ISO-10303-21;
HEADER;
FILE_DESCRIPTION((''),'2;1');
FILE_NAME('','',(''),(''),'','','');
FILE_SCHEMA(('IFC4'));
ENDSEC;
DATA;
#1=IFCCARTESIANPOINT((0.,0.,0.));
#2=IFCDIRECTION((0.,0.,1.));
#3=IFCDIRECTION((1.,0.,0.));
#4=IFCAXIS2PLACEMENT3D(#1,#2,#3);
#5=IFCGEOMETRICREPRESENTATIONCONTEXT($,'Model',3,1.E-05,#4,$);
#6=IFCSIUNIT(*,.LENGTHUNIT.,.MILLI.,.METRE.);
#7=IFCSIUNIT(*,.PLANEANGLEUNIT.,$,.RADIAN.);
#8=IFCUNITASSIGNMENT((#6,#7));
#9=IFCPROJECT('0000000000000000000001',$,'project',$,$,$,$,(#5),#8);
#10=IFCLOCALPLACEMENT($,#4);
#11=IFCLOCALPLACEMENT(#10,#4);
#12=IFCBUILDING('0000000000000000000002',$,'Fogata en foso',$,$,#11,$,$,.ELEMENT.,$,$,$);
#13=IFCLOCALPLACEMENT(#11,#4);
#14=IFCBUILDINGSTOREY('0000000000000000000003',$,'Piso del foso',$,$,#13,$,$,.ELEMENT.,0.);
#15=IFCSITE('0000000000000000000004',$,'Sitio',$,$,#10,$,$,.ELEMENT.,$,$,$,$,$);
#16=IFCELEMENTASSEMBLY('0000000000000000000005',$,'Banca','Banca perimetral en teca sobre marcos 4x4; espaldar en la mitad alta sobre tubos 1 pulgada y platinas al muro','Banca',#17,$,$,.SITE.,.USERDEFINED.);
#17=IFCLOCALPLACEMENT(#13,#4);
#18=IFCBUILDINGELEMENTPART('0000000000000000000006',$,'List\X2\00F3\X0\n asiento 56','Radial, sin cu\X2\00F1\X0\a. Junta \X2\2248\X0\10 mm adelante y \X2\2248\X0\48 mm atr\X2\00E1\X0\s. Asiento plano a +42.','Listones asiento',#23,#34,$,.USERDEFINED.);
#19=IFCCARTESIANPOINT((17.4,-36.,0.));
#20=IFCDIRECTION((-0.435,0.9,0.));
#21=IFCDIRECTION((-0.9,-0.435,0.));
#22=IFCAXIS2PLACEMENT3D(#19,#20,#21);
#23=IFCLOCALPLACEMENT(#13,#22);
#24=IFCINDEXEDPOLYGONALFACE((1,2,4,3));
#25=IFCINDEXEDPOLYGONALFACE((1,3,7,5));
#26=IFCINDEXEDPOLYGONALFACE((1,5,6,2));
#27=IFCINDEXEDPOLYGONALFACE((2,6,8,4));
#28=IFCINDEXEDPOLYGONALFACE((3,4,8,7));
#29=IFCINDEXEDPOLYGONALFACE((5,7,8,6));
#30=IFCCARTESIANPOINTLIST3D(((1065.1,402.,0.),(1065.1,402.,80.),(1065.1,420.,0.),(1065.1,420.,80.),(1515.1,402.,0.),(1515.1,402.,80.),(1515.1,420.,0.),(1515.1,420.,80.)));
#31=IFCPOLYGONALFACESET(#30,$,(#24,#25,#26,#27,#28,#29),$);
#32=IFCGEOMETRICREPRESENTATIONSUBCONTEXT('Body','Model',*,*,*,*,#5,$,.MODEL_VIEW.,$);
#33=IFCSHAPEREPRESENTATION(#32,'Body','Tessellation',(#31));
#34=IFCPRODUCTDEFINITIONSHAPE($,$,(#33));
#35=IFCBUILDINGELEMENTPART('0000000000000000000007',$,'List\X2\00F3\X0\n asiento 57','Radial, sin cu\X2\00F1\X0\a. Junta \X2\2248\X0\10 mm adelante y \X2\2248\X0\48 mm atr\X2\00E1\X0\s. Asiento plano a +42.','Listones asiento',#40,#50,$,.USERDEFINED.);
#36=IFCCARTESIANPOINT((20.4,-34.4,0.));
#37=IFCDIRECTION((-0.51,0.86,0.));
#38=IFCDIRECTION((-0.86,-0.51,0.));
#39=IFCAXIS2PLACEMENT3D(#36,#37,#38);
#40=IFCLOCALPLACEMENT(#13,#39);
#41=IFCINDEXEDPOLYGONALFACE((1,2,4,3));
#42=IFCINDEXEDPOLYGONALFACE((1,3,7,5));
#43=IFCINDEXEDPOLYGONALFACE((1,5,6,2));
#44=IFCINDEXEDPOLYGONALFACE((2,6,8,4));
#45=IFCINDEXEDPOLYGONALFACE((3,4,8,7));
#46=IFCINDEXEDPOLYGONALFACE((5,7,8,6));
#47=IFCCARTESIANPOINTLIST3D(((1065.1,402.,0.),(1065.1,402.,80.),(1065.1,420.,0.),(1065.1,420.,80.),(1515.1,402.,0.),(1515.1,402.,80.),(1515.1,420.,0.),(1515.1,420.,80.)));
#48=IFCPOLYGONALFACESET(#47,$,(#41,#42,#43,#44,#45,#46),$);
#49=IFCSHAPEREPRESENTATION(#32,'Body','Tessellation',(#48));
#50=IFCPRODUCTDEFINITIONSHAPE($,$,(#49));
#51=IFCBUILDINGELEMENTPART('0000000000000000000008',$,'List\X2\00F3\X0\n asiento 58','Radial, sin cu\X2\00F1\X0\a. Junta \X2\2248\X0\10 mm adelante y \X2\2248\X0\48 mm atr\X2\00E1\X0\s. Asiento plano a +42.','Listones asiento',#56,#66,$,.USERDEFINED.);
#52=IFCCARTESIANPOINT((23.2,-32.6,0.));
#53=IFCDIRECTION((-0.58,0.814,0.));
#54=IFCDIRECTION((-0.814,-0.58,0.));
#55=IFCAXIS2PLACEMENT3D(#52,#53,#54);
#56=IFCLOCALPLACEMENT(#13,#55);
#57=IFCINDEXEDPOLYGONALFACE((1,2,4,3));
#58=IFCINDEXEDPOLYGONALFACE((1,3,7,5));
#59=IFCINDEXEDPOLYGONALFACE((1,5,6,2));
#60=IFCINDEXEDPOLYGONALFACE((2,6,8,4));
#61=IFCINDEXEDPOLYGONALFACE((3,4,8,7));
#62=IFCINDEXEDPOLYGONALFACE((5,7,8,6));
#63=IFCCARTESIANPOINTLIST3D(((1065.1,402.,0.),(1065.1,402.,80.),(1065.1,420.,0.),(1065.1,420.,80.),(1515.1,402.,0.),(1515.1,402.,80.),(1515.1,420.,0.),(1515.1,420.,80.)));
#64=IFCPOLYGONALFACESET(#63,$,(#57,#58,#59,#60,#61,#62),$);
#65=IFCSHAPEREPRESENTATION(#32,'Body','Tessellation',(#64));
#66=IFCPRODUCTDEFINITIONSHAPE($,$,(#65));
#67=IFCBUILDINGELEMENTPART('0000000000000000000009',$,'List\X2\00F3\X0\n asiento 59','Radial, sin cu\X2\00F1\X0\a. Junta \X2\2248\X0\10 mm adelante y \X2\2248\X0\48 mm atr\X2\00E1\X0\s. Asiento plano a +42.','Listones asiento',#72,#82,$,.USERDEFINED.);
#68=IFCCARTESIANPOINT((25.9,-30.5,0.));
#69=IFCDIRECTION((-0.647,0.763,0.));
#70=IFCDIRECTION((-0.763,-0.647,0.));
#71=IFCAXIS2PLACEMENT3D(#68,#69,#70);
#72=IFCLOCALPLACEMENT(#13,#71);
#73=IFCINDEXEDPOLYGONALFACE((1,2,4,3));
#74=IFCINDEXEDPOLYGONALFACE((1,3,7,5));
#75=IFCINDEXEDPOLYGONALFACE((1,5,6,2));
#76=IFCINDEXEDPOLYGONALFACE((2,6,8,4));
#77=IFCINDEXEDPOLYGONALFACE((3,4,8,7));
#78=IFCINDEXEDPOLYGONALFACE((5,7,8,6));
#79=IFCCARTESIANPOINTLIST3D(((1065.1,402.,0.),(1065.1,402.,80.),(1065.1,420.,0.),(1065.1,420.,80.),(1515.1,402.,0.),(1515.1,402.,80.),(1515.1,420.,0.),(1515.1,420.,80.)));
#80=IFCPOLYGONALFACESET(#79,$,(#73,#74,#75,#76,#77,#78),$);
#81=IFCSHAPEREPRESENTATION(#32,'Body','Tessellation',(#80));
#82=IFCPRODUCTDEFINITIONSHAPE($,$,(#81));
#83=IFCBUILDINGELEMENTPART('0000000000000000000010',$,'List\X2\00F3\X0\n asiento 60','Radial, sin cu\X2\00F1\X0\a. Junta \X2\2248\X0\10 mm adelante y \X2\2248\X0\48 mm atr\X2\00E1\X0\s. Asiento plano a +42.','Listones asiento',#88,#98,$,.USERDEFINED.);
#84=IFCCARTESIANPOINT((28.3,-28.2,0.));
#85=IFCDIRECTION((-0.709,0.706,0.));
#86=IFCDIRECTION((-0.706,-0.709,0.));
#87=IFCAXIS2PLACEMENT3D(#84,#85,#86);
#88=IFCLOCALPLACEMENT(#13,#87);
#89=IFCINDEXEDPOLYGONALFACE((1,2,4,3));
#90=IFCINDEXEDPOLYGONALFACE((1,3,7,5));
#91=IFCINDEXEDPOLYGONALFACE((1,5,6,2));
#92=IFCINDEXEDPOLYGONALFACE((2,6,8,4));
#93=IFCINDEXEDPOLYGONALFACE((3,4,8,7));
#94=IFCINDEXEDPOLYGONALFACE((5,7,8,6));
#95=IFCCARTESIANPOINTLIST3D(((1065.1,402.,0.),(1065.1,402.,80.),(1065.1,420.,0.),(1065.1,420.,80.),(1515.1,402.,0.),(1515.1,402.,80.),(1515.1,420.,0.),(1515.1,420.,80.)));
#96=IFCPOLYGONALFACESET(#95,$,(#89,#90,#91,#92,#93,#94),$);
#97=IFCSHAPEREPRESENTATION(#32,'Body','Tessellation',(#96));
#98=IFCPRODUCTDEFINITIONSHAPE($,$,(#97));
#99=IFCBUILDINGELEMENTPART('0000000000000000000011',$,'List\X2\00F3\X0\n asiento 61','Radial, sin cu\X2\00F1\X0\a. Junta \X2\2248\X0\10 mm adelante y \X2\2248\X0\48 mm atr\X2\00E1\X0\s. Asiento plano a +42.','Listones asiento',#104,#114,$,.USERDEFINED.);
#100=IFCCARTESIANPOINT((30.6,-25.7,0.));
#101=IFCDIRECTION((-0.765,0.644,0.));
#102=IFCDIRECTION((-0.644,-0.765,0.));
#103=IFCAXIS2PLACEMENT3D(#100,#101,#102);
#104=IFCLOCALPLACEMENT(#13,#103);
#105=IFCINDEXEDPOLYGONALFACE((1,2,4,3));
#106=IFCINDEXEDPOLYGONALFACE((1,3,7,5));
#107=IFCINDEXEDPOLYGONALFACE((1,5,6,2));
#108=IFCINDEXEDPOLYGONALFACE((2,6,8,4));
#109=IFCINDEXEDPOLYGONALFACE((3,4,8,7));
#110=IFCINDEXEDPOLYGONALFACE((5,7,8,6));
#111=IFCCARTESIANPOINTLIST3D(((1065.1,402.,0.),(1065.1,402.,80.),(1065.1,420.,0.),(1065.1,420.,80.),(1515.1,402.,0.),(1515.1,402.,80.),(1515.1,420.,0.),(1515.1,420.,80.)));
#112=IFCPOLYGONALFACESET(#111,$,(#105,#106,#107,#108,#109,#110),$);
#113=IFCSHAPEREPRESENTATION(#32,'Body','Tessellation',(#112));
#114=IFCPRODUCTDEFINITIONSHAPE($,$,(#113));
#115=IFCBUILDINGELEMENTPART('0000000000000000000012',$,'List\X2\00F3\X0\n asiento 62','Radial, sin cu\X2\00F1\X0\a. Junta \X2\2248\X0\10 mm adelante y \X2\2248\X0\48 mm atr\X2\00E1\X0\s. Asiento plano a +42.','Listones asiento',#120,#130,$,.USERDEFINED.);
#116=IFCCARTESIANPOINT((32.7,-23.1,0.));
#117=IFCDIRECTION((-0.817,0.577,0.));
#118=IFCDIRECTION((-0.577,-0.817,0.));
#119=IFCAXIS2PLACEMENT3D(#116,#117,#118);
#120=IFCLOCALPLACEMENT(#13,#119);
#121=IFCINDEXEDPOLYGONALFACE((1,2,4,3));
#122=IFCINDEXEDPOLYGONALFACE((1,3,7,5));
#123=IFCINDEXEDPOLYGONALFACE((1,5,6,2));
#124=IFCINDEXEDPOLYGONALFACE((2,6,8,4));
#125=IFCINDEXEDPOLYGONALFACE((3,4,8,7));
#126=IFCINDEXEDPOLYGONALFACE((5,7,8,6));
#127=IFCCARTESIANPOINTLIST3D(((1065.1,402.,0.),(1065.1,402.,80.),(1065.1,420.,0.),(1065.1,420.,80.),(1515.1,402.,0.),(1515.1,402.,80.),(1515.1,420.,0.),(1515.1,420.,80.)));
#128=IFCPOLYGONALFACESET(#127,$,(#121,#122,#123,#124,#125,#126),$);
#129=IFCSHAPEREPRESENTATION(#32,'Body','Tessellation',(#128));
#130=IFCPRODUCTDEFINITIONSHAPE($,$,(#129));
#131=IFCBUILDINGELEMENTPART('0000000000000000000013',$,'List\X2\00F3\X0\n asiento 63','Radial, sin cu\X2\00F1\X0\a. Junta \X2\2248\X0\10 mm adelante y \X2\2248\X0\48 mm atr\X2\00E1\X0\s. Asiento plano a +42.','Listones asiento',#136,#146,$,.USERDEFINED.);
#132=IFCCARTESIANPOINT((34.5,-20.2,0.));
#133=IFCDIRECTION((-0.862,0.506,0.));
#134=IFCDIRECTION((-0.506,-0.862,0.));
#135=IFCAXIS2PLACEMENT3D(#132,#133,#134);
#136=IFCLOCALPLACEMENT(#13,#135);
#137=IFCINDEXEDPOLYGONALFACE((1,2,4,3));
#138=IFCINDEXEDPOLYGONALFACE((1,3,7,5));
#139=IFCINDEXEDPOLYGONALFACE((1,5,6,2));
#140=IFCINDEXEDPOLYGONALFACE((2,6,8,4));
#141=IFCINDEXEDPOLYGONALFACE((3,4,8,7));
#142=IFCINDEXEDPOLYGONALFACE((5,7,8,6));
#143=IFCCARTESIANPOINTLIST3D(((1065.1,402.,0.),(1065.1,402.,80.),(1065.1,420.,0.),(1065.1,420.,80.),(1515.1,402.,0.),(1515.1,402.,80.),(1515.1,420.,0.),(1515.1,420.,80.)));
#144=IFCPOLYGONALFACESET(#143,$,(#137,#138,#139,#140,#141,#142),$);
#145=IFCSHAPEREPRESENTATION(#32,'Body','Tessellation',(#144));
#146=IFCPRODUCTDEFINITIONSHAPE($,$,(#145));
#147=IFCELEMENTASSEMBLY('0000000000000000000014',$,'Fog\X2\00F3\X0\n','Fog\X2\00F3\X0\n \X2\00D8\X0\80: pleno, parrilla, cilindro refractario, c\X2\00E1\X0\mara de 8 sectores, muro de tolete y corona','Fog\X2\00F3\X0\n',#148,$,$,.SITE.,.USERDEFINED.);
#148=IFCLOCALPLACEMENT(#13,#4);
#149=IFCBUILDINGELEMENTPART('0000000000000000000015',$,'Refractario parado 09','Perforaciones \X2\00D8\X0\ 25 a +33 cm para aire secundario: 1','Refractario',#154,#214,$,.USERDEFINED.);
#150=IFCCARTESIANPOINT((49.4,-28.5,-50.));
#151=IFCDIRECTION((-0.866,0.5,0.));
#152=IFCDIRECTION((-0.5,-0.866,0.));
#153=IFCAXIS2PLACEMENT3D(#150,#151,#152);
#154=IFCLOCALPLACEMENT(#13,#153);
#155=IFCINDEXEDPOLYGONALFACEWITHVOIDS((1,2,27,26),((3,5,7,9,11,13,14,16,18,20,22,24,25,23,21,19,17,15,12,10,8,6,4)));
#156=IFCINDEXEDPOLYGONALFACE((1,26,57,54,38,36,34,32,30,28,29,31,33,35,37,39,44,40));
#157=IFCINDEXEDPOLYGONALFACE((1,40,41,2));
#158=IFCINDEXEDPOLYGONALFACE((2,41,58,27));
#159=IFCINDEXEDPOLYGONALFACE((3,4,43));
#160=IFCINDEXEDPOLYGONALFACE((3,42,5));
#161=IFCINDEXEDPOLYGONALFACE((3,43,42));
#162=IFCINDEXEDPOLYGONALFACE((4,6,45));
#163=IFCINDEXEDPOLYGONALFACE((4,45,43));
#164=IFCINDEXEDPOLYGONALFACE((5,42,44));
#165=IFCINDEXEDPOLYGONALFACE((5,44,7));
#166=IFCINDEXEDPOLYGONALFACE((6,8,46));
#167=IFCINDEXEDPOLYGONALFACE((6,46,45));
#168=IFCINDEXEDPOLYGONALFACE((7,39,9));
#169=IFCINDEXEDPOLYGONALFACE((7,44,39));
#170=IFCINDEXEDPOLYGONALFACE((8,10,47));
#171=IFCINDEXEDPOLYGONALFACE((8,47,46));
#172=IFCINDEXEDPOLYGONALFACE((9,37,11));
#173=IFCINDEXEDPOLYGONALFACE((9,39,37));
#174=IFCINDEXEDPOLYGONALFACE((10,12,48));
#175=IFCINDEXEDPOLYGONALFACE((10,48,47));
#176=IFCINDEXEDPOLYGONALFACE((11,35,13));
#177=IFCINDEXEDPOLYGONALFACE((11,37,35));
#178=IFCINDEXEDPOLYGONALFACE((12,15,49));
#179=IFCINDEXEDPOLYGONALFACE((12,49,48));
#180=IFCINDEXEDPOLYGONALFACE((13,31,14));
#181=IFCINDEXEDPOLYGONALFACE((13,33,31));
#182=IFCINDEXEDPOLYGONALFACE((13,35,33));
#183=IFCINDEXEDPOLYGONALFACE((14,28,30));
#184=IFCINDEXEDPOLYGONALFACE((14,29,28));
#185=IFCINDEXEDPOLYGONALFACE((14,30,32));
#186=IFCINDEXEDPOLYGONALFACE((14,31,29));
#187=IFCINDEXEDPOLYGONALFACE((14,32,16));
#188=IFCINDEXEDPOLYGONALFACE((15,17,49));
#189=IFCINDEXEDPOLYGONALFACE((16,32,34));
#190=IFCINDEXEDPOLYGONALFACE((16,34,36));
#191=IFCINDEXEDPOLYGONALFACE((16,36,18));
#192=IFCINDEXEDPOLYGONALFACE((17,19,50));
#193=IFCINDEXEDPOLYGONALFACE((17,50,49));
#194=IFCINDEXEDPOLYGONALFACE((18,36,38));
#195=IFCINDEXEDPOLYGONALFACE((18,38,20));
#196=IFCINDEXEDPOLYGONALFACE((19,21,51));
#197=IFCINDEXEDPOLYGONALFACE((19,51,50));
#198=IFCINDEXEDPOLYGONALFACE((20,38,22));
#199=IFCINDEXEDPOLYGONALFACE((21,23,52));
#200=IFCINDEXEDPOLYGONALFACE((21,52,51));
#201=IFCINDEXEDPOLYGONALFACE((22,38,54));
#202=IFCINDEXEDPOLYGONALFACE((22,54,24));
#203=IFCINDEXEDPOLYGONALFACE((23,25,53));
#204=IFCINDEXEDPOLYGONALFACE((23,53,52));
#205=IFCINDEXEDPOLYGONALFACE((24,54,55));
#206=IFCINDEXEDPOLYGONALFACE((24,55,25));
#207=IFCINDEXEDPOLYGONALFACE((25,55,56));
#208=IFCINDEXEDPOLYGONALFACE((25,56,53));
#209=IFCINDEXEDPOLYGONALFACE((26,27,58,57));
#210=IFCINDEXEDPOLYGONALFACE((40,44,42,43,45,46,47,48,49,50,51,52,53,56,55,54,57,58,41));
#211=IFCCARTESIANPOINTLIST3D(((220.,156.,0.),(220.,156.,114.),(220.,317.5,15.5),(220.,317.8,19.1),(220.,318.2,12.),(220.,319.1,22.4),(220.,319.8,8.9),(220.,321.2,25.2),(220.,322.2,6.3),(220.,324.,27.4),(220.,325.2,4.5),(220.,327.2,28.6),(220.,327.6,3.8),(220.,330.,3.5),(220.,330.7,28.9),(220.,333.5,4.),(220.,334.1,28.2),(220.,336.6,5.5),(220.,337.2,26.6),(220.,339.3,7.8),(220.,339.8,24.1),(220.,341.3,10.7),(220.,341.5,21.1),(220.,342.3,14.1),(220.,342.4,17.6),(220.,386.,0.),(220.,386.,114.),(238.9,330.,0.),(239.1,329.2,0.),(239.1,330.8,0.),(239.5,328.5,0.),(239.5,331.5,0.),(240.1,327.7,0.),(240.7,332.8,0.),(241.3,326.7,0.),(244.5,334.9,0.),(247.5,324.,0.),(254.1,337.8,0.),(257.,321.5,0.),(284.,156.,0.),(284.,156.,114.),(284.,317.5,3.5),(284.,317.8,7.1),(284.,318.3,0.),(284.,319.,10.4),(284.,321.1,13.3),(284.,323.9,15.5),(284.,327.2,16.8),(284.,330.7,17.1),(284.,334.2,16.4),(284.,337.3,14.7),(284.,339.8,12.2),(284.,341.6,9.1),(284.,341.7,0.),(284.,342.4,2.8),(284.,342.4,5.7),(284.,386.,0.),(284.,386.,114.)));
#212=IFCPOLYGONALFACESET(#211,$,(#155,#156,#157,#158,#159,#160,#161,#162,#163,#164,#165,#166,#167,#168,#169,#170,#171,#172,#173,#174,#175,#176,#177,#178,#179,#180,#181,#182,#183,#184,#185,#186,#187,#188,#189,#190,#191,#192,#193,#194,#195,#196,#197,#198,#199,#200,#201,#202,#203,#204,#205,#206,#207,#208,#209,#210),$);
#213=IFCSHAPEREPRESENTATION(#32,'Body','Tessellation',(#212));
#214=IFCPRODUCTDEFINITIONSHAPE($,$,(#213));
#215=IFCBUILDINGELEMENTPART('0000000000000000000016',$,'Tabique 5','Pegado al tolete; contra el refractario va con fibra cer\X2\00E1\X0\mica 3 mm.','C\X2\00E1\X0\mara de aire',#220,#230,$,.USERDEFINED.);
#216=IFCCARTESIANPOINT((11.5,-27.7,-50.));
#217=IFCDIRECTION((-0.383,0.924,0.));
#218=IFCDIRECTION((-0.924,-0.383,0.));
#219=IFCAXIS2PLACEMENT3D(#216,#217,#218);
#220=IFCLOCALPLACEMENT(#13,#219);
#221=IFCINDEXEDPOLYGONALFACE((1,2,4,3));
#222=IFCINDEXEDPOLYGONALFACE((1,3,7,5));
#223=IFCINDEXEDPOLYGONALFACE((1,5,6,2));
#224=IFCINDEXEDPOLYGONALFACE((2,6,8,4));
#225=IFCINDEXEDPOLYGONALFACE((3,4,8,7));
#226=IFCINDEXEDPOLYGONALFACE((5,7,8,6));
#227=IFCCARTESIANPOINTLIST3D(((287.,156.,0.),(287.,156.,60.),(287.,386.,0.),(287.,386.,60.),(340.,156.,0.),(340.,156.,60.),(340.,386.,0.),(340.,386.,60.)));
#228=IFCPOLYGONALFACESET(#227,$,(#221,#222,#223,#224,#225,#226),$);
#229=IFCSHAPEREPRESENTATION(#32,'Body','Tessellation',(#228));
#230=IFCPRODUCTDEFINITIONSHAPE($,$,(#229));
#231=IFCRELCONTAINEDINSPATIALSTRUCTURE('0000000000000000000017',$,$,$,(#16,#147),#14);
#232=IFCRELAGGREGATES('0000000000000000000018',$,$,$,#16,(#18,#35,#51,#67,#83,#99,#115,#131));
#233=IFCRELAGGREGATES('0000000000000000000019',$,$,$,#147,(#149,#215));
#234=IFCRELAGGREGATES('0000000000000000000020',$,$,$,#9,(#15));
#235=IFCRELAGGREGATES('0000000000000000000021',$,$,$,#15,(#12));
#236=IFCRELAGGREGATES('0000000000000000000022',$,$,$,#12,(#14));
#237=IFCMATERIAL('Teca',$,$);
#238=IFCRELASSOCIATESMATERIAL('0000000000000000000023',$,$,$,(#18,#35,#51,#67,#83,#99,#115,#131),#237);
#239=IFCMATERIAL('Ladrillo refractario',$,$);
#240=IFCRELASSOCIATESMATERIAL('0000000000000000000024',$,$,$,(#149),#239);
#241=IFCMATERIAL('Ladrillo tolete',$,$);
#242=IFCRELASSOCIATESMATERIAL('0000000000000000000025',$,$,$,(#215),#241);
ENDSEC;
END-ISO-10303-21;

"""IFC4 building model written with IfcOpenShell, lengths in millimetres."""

from ifc_helpers import new_model, si_unit, frame, origin_with_axes, origin_2d, place, context, subcontext, project, spatial, polyline, circle, outline, extrude, material, element, aggregate, save


model = new_model("IFC4")

# Units and contexts
model_context = context("Model", 3, precision=1e-05, world=origin_with_axes())
body_context = subcontext(model_context, "Body", "Model", "MODEL_VIEW")
ifc_project = project(units=[si_unit("LENGTHUNIT", "METRE", prefix="MILLI"), si_unit("PLANEANGLEUNIT", "RADIAN")], contexts=[model_context])

# Site, building, storey
site_placement = place(None, origin_with_axes())
site = spatial("IfcSite", under=ifc_project, at=site_placement, Name="Sitio", CompositionType="ELEMENT")
building_placement = place(site_placement, origin_with_axes())
building = spatial("IfcBuilding", under=site, at=building_placement, Name="Fogata en foso", CompositionType="ELEMENT")
storey_placement = place(building_placement, origin_with_axes())
storey = spatial("IfcBuildingStorey", under=building, at=storey_placement, Name="Piso del foso", CompositionType="ELEMENT", Elevation=0.0)

# Element assembly, building element parts
assembly_1_placement = place(storey_placement, origin_with_axes())
assembly_1 = element("IfcElementAssembly", 1, at=assembly_1_placement, inside=storey, Name="Banca", Description="Banca perimetral en teca sobre marcos 4x4; espaldar en la mitad alta sobre tubos 1 pulgada y platinas al muro", ObjectType="Banca", AssemblyPlace="SITE", PredefinedType="USERDEFINED")
ifc_material_1 = material(Name="Teca")
building_element_part_1_placement = place(storey_placement, frame((17.4, -36.0, 0.0), z_axis=(-0.435, 0.9, 0.0), x_axis=(-0.9, -0.435, 0.0)))
building_element_part_1 = element("IfcBuildingElementPart", 2, at=building_element_part_1_placement, material=ifc_material_1, Name="Listón asiento 56", Description="Radial, sin cuña. Junta ≈10 mm adelante y ≈48 mm atrás. Asiento plano a +42.", ObjectType="Listones asiento", PredefinedType="USERDEFINED", context=body_context, shape_type="SweptSolid", body=[
    extrude(outline(polyline([(1065.1, 402.0), (1515.1, 402.0), (1515.1, 420.0), (1065.1, 420.0), (1065.1, 402.0)])), origin_with_axes(), (0.0, 0.0, 1.0), 80.0),
])
building_element_part_2_placement = place(storey_placement, frame((20.4, -34.4, 0.0), z_axis=(-0.51, 0.86, 0.0), x_axis=(-0.86, -0.51, 0.0)))
building_element_part_2 = element("IfcBuildingElementPart", 3, at=building_element_part_2_placement, material=ifc_material_1, Name="Listón asiento 57", Description="Radial, sin cuña. Junta ≈10 mm adelante y ≈48 mm atrás. Asiento plano a +42.", ObjectType="Listones asiento", PredefinedType="USERDEFINED", context=body_context, shape_type="SweptSolid", body=[
    extrude(outline(polyline([(1065.1, 402.0), (1515.1, 402.0), (1515.1, 420.0), (1065.1, 420.0), (1065.1, 402.0)])), origin_with_axes(), (0.0, 0.0, 1.0), 80.0),
])
building_element_part_3_placement = place(storey_placement, frame((23.2, -32.6, 0.0), z_axis=(-0.58, 0.814, 0.0), x_axis=(-0.814, -0.58, 0.0)))
building_element_part_3 = element("IfcBuildingElementPart", 4, at=building_element_part_3_placement, material=ifc_material_1, Name="Listón asiento 58", Description="Radial, sin cuña. Junta ≈10 mm adelante y ≈48 mm atrás. Asiento plano a +42.", ObjectType="Listones asiento", PredefinedType="USERDEFINED", context=body_context, shape_type="SweptSolid", body=[
    extrude(outline(polyline([(1065.1, 402.0), (1515.1, 402.0), (1515.1, 420.0), (1065.1, 420.0), (1065.1, 402.0)])), origin_with_axes(), (0.0, 0.0, 1.0), 80.0),
])
building_element_part_4_placement = place(storey_placement, frame((25.9, -30.5, 0.0), z_axis=(-0.647, 0.763, 0.0), x_axis=(-0.763, -0.647, 0.0)))
building_element_part_4 = element("IfcBuildingElementPart", 5, at=building_element_part_4_placement, material=ifc_material_1, Name="Listón asiento 59", Description="Radial, sin cuña. Junta ≈10 mm adelante y ≈48 mm atrás. Asiento plano a +42.", ObjectType="Listones asiento", PredefinedType="USERDEFINED", context=body_context, shape_type="SweptSolid", body=[
    extrude(outline(polyline([(1065.1, 402.0), (1515.1, 402.0), (1515.1, 420.0), (1065.1, 420.0), (1065.1, 402.0)])), origin_with_axes(), (0.0, 0.0, 1.0), 80.0),
])
building_element_part_5_placement = place(storey_placement, frame((28.3, -28.2, 0.0), z_axis=(-0.709, 0.706, 0.0), x_axis=(-0.706, -0.709, 0.0)))
building_element_part_5 = element("IfcBuildingElementPart", 6, at=building_element_part_5_placement, material=ifc_material_1, Name="Listón asiento 60", Description="Radial, sin cuña. Junta ≈10 mm adelante y ≈48 mm atrás. Asiento plano a +42.", ObjectType="Listones asiento", PredefinedType="USERDEFINED", context=body_context, shape_type="SweptSolid", body=[
    extrude(outline(polyline([(1065.1, 402.0), (1515.1, 402.0), (1515.1, 420.0), (1065.1, 420.0), (1065.1, 402.0)])), origin_with_axes(), (0.0, 0.0, 1.0), 80.0),
])
building_element_part_6_placement = place(storey_placement, frame((30.6, -25.7, 0.0), z_axis=(-0.765, 0.644, 0.0), x_axis=(-0.644, -0.765, 0.0)))
building_element_part_6 = element("IfcBuildingElementPart", 7, at=building_element_part_6_placement, material=ifc_material_1, Name="Listón asiento 61", Description="Radial, sin cuña. Junta ≈10 mm adelante y ≈48 mm atrás. Asiento plano a +42.", ObjectType="Listones asiento", PredefinedType="USERDEFINED", context=body_context, shape_type="SweptSolid", body=[
    extrude(outline(polyline([(1065.1, 402.0), (1515.1, 402.0), (1515.1, 420.0), (1065.1, 420.0), (1065.1, 402.0)])), origin_with_axes(), (0.0, 0.0, 1.0), 80.0),
])
building_element_part_7_placement = place(storey_placement, frame((32.7, -23.1, 0.0), z_axis=(-0.817, 0.577, 0.0), x_axis=(-0.577, -0.817, 0.0)))
building_element_part_7 = element("IfcBuildingElementPart", 8, at=building_element_part_7_placement, material=ifc_material_1, Name="Listón asiento 62", Description="Radial, sin cuña. Junta ≈10 mm adelante y ≈48 mm atrás. Asiento plano a +42.", ObjectType="Listones asiento", PredefinedType="USERDEFINED", context=body_context, shape_type="SweptSolid", body=[
    extrude(outline(polyline([(1065.1, 402.0), (1515.1, 402.0), (1515.1, 420.0), (1065.1, 420.0), (1065.1, 402.0)])), origin_with_axes(), (0.0, 0.0, 1.0), 80.0),
])
building_element_part_8_placement = place(storey_placement, frame((34.5, -20.2, 0.0), z_axis=(-0.862, 0.506, 0.0), x_axis=(-0.506, -0.862, 0.0)))
building_element_part_8 = element("IfcBuildingElementPart", 9, at=building_element_part_8_placement, material=ifc_material_1, Name="Listón asiento 63", Description="Radial, sin cuña. Junta ≈10 mm adelante y ≈48 mm atrás. Asiento plano a +42.", ObjectType="Listones asiento", PredefinedType="USERDEFINED", context=body_context, shape_type="SweptSolid", body=[
    extrude(outline(polyline([(1065.1, 402.0), (1515.1, 402.0), (1515.1, 420.0), (1065.1, 420.0), (1065.1, 402.0)])), origin_with_axes(), (0.0, 0.0, 1.0), 80.0),
])
aggregate(assembly_1, [building_element_part_1, building_element_part_2, building_element_part_3, building_element_part_4, building_element_part_5, building_element_part_6, building_element_part_7, building_element_part_8])

# Element assembly, building element parts, opening
assembly_2_placement = place(storey_placement, origin_with_axes())
assembly_2 = element("IfcElementAssembly", 10, at=assembly_2_placement, inside=storey, Name="Fogón", Description="Fogón Ø80: pleno, parrilla, cilindro refractario, cámara de 8 sectores, muro de tolete y corona", ObjectType="Fogón", AssemblyPlace="SITE", PredefinedType="USERDEFINED")
ifc_material_2 = material(Name="Ladrillo refractario")
building_element_part_9_placement = place(storey_placement, frame((49.4, -28.5, -50.0), z_axis=(-0.866, 0.5, 0.0), x_axis=(-0.5, -0.866, 0.0)))
building_element_part_9 = element("IfcBuildingElementPart", 11, at=building_element_part_9_placement, material=ifc_material_2, Name="Refractario parado 09", Description="Perforaciones Ø 25 a +33 cm para aire secundario: 1", ObjectType="Refractario", PredefinedType="USERDEFINED", context=body_context, shape_type="SweptSolid", body=[
    extrude(outline(polyline([(220.0, 156.0), (284.0, 156.0), (284.0, 386.0), (220.0, 386.0), (220.0, 156.0)])), origin_with_axes(), (0.0, 0.0, 1.0), 114.0),
])
opening_1_placement = place(storey_placement, frame((-65.1, -183.8, 280.0), z_axis=(-0.334, -0.943, 0.0), x_axis=(0.943, -0.334, 0.0)))
element("IfcOpeningElement", 12, at=opening_1_placement, cuts=building_element_part_9, PredefinedType="OPENING", context=body_context, shape_type="SweptSolid", body=[
    extrude(circle(Radius=12.5, at=origin_2d()), origin_with_axes(), (0.0, 0.0, 1.0), 110.0),
])
ifc_material_3 = material(Name="Ladrillo tolete")
building_element_part_10_placement = place(storey_placement, frame((11.5, -27.7, -50.0), z_axis=(-0.383, 0.924, 0.0), x_axis=(-0.924, -0.383, 0.0)))
building_element_part_10 = element("IfcBuildingElementPart", 13, at=building_element_part_10_placement, material=ifc_material_3, Name="Tabique 5", Description="Pegado al tolete; contra el refractario va con fibra cerámica 3 mm.", ObjectType="Cámara de aire", PredefinedType="USERDEFINED", context=body_context, shape_type="SweptSolid", body=[
    extrude(outline(polyline([(287.0, 156.0), (340.0, 156.0), (340.0, 386.0), (287.0, 386.0), (287.0, 156.0)])), origin_with_axes(), (0.0, 0.0, 1.0), 60.0),
])
aggregate(assembly_2, [building_element_part_9, building_element_part_10])

save(model, "model.ifc")
